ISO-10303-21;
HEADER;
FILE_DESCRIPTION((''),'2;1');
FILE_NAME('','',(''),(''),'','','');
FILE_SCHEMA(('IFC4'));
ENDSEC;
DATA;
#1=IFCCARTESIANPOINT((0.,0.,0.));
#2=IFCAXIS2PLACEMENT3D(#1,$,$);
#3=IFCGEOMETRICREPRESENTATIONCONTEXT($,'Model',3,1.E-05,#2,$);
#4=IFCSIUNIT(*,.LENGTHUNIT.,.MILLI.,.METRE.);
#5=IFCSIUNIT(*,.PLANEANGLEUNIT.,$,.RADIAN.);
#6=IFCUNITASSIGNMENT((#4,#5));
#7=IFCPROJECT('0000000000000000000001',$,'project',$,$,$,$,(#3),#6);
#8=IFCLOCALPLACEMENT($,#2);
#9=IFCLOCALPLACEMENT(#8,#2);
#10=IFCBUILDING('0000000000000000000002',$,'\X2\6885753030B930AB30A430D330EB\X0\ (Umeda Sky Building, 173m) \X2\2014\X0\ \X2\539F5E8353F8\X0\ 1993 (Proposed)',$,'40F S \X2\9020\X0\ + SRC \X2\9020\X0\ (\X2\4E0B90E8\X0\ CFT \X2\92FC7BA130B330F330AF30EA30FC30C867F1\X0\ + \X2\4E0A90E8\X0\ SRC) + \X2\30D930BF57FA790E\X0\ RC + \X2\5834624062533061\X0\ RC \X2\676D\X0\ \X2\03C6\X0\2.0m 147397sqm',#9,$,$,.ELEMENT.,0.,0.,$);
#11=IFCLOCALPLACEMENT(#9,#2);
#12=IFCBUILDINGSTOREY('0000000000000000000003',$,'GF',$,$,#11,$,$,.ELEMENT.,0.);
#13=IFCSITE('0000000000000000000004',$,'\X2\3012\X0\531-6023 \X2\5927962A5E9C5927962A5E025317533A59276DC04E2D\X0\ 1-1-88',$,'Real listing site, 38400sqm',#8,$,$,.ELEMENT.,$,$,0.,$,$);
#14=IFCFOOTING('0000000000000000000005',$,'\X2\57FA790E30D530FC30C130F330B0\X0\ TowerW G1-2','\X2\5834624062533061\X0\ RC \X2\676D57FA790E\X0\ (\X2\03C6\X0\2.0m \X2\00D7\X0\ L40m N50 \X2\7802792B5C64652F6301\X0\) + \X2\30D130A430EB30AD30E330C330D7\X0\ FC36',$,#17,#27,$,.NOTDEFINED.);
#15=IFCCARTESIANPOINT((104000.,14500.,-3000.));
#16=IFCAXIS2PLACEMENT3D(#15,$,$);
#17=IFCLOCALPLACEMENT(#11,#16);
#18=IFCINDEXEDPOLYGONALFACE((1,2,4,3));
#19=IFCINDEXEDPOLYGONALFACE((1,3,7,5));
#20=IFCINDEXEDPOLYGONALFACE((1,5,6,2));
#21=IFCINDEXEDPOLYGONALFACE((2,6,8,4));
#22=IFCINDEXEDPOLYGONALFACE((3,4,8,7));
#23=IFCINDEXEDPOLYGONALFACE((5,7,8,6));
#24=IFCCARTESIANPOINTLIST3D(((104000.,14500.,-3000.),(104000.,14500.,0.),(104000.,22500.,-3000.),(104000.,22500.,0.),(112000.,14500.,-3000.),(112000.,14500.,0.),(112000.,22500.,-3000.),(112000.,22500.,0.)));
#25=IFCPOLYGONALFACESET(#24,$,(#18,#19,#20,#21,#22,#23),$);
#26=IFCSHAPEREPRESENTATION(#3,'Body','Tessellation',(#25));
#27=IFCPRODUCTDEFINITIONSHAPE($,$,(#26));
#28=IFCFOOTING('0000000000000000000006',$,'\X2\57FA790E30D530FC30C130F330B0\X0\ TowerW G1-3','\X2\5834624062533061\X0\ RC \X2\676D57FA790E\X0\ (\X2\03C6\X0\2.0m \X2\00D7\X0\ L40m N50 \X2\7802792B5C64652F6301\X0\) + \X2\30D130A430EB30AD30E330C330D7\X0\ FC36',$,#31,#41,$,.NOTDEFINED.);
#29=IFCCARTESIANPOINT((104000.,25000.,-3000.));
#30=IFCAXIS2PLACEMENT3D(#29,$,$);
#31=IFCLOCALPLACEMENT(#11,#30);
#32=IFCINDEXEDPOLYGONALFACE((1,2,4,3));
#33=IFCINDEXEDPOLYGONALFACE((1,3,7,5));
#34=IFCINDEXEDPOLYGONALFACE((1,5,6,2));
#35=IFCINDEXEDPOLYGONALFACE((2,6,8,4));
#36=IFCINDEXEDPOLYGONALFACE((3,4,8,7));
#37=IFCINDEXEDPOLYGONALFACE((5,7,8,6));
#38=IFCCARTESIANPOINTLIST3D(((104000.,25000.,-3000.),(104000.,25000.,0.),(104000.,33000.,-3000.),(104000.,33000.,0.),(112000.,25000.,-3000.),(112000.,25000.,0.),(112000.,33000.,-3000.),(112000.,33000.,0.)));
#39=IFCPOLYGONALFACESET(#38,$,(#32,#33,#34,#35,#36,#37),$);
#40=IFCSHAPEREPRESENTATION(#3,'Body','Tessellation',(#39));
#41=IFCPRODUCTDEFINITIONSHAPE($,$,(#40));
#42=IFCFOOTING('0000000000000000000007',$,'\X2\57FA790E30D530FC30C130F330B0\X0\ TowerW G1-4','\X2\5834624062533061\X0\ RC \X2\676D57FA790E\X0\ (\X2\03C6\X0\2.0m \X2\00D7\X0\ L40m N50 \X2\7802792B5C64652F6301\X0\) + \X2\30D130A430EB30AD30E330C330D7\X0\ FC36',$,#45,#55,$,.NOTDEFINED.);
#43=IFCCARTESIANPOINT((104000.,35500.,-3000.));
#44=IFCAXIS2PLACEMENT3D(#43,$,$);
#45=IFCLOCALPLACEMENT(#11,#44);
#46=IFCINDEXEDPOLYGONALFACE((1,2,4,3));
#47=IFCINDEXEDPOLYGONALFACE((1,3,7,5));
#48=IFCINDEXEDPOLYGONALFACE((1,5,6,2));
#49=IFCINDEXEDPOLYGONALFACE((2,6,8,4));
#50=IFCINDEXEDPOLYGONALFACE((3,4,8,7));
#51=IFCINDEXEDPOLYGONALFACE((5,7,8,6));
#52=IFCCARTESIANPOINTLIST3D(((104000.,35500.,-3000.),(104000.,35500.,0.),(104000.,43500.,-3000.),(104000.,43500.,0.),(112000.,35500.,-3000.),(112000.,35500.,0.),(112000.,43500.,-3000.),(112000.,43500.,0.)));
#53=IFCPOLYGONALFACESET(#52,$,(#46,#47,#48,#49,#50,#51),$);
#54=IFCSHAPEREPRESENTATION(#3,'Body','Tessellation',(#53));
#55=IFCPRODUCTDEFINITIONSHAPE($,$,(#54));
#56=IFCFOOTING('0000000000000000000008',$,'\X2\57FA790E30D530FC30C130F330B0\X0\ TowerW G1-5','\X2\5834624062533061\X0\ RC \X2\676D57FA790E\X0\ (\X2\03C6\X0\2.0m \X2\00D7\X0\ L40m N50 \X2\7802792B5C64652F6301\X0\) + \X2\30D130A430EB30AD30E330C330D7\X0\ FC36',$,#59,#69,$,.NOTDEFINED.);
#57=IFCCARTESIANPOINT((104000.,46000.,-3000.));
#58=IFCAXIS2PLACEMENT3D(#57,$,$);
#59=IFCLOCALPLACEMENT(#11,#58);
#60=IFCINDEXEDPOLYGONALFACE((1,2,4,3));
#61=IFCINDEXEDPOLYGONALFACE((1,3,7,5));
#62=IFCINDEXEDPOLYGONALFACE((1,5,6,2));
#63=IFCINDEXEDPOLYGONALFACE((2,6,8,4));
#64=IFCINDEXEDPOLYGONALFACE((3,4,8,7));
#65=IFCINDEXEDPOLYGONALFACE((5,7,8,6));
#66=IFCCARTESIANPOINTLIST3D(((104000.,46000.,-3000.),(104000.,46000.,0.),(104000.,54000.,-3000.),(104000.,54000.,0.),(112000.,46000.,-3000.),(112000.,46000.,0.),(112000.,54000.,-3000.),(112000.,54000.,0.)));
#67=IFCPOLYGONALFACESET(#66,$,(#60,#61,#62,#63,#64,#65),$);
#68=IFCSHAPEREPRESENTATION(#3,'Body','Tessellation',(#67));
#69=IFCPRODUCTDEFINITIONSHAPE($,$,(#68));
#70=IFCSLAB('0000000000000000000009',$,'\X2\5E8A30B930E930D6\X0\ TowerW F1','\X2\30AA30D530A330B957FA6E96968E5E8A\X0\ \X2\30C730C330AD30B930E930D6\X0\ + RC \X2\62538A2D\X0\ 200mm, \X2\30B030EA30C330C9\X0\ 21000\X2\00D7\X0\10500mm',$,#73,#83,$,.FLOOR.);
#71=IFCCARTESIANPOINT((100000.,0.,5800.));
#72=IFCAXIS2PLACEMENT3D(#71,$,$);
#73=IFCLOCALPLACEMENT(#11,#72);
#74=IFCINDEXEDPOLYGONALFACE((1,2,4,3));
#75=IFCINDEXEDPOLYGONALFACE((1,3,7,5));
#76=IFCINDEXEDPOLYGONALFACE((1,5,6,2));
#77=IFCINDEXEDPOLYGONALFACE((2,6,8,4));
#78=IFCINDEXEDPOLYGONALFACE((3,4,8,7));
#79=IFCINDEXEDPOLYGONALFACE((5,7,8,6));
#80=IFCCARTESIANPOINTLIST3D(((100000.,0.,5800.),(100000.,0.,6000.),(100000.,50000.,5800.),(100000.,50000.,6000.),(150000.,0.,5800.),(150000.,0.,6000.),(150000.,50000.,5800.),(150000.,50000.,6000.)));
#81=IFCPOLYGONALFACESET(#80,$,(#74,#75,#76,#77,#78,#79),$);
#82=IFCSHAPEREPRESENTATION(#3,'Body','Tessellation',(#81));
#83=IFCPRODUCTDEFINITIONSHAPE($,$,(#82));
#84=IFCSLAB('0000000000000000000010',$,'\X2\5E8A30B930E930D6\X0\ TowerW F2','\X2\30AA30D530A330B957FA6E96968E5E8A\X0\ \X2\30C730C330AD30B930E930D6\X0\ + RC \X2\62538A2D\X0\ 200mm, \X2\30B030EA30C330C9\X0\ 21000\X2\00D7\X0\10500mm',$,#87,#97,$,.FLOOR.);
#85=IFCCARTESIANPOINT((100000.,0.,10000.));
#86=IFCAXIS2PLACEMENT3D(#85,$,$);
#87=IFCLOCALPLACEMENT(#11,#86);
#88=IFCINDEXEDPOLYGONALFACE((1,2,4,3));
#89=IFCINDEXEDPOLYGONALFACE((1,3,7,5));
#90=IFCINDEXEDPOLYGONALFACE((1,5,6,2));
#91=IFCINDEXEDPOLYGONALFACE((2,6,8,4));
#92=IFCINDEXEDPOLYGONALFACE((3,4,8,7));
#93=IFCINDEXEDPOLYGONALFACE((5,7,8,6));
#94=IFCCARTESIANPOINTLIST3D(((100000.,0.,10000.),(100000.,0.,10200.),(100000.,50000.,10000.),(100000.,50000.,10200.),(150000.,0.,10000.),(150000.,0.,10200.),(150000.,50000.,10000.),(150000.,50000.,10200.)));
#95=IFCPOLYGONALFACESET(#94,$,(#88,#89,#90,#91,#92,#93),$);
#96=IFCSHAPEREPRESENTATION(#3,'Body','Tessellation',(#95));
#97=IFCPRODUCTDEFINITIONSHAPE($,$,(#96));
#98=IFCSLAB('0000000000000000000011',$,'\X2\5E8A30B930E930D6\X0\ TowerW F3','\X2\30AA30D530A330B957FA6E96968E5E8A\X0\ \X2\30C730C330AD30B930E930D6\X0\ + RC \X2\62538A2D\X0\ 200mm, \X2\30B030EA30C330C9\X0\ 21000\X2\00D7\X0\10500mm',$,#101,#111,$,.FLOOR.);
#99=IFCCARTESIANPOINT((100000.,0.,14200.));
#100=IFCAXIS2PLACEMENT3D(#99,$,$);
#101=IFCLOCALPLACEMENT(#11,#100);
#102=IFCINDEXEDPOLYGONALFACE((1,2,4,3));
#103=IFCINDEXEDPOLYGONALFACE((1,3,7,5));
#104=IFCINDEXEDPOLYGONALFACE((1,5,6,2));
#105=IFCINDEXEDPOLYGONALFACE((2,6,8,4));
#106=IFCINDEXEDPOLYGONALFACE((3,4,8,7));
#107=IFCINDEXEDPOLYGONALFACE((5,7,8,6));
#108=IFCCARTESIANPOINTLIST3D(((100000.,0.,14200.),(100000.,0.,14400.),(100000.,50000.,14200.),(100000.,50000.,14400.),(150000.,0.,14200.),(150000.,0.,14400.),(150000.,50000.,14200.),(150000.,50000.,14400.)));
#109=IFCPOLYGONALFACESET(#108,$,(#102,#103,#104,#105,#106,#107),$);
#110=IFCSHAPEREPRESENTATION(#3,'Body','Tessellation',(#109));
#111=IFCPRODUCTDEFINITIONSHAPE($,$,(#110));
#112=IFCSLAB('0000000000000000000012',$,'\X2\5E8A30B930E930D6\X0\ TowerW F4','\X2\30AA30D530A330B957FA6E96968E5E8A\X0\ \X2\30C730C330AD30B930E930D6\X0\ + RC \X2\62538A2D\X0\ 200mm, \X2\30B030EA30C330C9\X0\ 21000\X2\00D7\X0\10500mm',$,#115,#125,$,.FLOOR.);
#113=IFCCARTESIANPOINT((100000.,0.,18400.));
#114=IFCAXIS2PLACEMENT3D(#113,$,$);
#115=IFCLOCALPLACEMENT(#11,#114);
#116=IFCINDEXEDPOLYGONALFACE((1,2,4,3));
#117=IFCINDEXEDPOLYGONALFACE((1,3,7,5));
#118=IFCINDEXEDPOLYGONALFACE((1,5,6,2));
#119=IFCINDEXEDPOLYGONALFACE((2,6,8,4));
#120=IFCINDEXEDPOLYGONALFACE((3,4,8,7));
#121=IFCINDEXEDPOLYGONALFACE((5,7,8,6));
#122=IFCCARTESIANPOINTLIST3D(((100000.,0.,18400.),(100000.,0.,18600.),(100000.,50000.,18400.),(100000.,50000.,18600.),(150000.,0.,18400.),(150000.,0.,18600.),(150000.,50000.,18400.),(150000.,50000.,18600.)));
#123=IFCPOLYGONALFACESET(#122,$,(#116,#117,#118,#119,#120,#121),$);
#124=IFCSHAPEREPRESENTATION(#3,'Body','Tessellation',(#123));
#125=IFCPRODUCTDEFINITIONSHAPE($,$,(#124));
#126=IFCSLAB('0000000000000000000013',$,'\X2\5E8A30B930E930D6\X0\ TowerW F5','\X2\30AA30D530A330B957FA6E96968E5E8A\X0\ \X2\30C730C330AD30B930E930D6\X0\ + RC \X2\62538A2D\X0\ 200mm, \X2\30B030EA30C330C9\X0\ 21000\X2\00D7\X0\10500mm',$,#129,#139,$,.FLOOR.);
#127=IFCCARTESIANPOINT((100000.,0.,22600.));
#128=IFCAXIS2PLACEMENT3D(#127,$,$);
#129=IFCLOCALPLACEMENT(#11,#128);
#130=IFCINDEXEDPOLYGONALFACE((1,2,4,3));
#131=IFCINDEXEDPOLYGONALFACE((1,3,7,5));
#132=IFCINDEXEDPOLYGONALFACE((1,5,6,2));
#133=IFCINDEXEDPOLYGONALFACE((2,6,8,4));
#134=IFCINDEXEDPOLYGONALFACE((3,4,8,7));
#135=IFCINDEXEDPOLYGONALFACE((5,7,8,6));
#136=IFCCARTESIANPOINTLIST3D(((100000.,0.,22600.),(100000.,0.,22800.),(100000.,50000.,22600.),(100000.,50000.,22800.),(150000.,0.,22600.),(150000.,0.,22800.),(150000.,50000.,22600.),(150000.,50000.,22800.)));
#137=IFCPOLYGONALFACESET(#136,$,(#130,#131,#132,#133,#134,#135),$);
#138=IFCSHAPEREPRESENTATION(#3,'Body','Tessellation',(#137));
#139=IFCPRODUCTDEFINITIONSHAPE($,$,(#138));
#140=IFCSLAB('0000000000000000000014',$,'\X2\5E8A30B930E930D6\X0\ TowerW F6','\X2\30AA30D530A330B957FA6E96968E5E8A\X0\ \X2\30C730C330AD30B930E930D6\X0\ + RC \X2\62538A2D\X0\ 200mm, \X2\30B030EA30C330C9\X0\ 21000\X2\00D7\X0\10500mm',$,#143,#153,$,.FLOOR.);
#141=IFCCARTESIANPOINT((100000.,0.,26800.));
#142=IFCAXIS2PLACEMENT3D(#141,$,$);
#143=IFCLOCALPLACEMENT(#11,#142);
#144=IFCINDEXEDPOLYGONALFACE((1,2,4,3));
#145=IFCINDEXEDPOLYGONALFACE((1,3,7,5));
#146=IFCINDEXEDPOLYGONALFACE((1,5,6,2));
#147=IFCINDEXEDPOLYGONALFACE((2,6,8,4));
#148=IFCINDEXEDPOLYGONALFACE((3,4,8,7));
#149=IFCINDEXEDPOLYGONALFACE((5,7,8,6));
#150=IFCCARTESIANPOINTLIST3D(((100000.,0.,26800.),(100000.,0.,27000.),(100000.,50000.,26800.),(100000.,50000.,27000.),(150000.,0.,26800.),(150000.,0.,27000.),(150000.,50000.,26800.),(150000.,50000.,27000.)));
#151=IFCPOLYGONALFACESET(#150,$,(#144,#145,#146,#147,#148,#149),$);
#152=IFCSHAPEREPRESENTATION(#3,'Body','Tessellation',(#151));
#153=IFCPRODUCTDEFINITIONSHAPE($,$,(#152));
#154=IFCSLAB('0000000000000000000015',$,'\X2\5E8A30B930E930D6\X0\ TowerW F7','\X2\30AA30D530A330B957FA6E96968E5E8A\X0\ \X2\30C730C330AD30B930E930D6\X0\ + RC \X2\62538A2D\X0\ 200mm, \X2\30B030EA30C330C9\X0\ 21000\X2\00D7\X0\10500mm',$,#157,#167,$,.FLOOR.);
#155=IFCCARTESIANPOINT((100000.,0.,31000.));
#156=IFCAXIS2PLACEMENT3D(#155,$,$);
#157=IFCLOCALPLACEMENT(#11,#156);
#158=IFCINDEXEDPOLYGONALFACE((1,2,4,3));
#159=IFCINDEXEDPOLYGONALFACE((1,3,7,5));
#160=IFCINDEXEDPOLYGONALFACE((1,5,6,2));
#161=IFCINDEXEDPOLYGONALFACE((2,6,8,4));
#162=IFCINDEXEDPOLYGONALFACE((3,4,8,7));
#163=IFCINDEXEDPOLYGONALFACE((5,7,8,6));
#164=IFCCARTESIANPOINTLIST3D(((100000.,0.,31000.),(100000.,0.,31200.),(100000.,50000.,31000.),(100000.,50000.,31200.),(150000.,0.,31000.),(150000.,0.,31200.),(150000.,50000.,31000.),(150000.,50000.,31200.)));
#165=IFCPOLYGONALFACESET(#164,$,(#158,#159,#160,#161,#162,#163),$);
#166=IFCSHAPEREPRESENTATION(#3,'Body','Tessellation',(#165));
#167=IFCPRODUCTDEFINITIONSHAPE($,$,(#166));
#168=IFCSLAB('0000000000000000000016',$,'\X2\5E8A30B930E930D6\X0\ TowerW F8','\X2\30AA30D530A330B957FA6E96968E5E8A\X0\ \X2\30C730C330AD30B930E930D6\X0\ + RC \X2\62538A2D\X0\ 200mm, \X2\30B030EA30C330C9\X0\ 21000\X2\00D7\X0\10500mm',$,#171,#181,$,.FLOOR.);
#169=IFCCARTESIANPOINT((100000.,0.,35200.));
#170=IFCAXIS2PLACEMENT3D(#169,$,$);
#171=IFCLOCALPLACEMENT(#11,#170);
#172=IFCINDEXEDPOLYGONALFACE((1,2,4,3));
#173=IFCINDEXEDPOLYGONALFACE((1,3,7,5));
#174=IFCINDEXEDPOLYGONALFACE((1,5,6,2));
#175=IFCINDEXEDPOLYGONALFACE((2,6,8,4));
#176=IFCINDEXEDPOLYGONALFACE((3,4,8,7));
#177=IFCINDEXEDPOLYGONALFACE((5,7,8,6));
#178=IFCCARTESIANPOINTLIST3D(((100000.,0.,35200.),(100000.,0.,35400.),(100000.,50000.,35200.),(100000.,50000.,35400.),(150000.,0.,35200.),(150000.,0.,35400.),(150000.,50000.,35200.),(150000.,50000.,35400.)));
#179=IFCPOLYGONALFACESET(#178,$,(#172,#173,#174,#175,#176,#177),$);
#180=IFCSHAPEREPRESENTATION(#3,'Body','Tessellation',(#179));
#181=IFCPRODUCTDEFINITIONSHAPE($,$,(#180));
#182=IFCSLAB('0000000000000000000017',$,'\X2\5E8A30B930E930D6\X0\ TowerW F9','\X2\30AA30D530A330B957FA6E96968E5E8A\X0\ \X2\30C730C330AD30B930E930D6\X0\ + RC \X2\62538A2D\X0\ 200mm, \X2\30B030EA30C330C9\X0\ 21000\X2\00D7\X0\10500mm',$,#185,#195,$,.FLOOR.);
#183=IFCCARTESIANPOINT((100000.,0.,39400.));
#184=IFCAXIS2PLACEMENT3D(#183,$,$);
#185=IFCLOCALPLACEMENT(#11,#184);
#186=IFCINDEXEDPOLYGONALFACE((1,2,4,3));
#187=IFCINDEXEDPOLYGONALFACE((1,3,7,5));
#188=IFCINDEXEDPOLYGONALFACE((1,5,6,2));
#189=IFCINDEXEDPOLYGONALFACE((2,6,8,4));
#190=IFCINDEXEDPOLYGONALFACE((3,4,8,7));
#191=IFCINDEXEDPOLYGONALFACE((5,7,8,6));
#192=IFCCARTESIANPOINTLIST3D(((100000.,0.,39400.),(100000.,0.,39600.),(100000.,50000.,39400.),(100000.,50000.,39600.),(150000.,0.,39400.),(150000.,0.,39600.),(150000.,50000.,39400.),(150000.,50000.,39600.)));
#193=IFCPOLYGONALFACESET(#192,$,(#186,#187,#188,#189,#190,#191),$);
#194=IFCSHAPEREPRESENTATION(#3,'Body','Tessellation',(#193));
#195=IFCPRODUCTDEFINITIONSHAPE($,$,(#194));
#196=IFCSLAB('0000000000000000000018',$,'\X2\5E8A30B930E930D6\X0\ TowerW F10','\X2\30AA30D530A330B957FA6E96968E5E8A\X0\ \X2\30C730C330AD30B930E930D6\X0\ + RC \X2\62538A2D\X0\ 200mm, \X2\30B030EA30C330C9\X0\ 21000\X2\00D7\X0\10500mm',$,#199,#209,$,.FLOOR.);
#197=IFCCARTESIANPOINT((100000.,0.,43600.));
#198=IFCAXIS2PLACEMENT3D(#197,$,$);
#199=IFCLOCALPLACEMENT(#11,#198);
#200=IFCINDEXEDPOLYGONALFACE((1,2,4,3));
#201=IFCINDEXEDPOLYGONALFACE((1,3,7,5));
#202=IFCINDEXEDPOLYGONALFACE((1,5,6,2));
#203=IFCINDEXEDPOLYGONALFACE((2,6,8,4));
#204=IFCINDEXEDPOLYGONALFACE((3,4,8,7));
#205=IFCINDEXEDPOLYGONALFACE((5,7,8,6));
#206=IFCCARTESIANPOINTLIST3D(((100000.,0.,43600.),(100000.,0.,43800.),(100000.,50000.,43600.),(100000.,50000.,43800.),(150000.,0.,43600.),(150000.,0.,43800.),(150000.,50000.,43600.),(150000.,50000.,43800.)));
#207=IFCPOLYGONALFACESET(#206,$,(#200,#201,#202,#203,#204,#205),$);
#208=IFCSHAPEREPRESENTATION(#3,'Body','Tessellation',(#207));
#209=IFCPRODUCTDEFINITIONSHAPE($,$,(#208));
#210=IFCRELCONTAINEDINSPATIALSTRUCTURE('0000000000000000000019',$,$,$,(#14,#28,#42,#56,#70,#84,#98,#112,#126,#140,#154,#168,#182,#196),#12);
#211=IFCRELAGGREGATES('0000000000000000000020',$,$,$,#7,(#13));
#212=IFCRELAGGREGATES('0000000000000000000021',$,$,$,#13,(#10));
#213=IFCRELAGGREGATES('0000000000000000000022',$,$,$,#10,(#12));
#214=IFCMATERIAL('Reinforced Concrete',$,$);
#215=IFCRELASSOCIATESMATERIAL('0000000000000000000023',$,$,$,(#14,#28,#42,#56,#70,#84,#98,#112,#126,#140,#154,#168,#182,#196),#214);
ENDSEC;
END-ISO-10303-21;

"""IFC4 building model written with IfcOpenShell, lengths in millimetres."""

from ifc_helpers import new_model, si_unit, frame, frame_2d, origin, place, context, project, spatial, rectangle, extrude, material, element, save


model = new_model("IFC4")

# Units and contexts
model_context = context("Model", 3, precision=1e-05, world=origin())
ifc_project = project(units=[si_unit("LENGTHUNIT", "METRE", prefix="MILLI"), si_unit("PLANEANGLEUNIT", "RADIAN")], contexts=[model_context])

# Site, building, storey
site_placement = place(None, origin())
site = spatial("IfcSite", under=ifc_project, at=site_placement, Name="〒531-6023 大阪府大阪市北区大淀中 1-1-88", ObjectType="Real listing site, 38400sqm", CompositionType="ELEMENT", RefElevation=0.0)
building_placement = place(site_placement, origin())
building = spatial("IfcBuilding", under=site, at=building_placement, Name="梅田スカイビル (Umeda Sky Building, 173m) — 原広司 1993 (Proposed)", ObjectType="40F S 造 + SRC 造 (下部 CFT 鋼管コンクリート柱 + 上部 SRC) + ベタ基礎 RC + 場所打ち RC 杭 φ2.0m 147397sqm", CompositionType="ELEMENT", ElevationOfRefHeight=0.0, ElevationOfTerrain=0.0)
storey_placement = place(building_placement, origin())
storey = spatial("IfcBuildingStorey", under=building, at=storey_placement, Name="GF", CompositionType="ELEMENT", Elevation=0.0)

# Footings
ifc_material_1 = material(Name="Reinforced Concrete")
footing_1_placement = place(storey_placement, frame((104000.0, 14500.0, -3000.0)))
element("IfcFooting", 1, at=footing_1_placement, inside=storey, material=ifc_material_1, Name="基礎フーチング TowerW G1-2", Description="場所打ち RC 杭基礎 (φ2.0m × L40m N50 砂礫層支持) + パイルキャップ FC36", PredefinedType="NOTDEFINED", context=model_context, shape_type="SweptSolid", body=[
    extrude(rectangle(XDim=8000.0, YDim=8000.0, at=frame_2d((4000.0, 4000.0))), frame((104000.0, 14500.0, -3000.0)), (0.0, 0.0, 1.0), 3000.0),
])
footing_2_placement = place(storey_placement, frame((104000.0, 25000.0, -3000.0)))
element("IfcFooting", 2, at=footing_2_placement, inside=storey, material=ifc_material_1, Name="基礎フーチング TowerW G1-3", Description="場所打ち RC 杭基礎 (φ2.0m × L40m N50 砂礫層支持) + パイルキャップ FC36", PredefinedType="NOTDEFINED", context=model_context, shape_type="SweptSolid", body=[
    extrude(rectangle(XDim=8000.0, YDim=8000.0, at=frame_2d((4000.0, 4000.0))), frame((104000.0, 25000.0, -3000.0)), (0.0, 0.0, 1.0), 3000.0),
])
footing_3_placement = place(storey_placement, frame((104000.0, 35500.0, -3000.0)))
element("IfcFooting", 3, at=footing_3_placement, inside=storey, material=ifc_material_1, Name="基礎フーチング TowerW G1-4", Description="場所打ち RC 杭基礎 (φ2.0m × L40m N50 砂礫層支持) + パイルキャップ FC36", PredefinedType="NOTDEFINED", context=model_context, shape_type="SweptSolid", body=[
    extrude(rectangle(XDim=8000.0, YDim=8000.0, at=frame_2d((4000.0, 4000.0))), frame((104000.0, 35500.0, -3000.0)), (0.0, 0.0, 1.0), 3000.0),
])
footing_4_placement = place(storey_placement, frame((104000.0, 46000.0, -3000.0)))
element("IfcFooting", 4, at=footing_4_placement, inside=storey, material=ifc_material_1, Name="基礎フーチング TowerW G1-5", Description="場所打ち RC 杭基礎 (φ2.0m × L40m N50 砂礫層支持) + パイルキャップ FC36", PredefinedType="NOTDEFINED", context=model_context, shape_type="SweptSolid", body=[
    extrude(rectangle(XDim=8000.0, YDim=8000.0, at=frame_2d((4000.0, 4000.0))), frame((104000.0, 46000.0, -3000.0)), (0.0, 0.0, 1.0), 3000.0),
])

# Slabs
slab_1_placement = place(storey_placement, frame((100000.0, 0.0, 5800.0)))
element("IfcSlab", 5, at=slab_1_placement, inside=storey, material=ifc_material_1, Name="床スラブ TowerW F1", Description="オフィス基準階床 デッキスラブ + RC 打設 200mm, グリッド 21000×10500mm", PredefinedType="FLOOR", context=model_context, shape_type="SweptSolid", body=[
    extrude(rectangle(XDim=50000.0, YDim=50000.0, at=frame_2d((25000.0, 25000.0))), frame((100000.0, 0.0, 5800.0)), (0.0, 0.0, 1.0), 200.0),
])
slab_2_placement = place(storey_placement, frame((100000.0, 0.0, 10000.0)))
element("IfcSlab", 6, at=slab_2_placement, inside=storey, material=ifc_material_1, Name="床スラブ TowerW F2", Description="オフィス基準階床 デッキスラブ + RC 打設 200mm, グリッド 21000×10500mm", PredefinedType="FLOOR", context=model_context, shape_type="SweptSolid", body=[
    extrude(rectangle(XDim=50000.0, YDim=50000.0, at=frame_2d((25000.0, 25000.0))), frame((100000.0, 0.0, 10000.0)), (0.0, 0.0, 1.0), 200.0),
])
slab_3_placement = place(storey_placement, frame((100000.0, 0.0, 14200.0)))
element("IfcSlab", 7, at=slab_3_placement, inside=storey, material=ifc_material_1, Name="床スラブ TowerW F3", Description="オフィス基準階床 デッキスラブ + RC 打設 200mm, グリッド 21000×10500mm", PredefinedType="FLOOR", context=model_context, shape_type="SweptSolid", body=[
    extrude(rectangle(XDim=50000.0, YDim=50000.0, at=frame_2d((25000.0, 25000.0))), frame((100000.0, 0.0, 14200.0)), (0.0, 0.0, 1.0), 200.0),
])
slab_4_placement = place(storey_placement, frame((100000.0, 0.0, 18400.0)))
element("IfcSlab", 8, at=slab_4_placement, inside=storey, material=ifc_material_1, Name="床スラブ TowerW F4", Description="オフィス基準階床 デッキスラブ + RC 打設 200mm, グリッド 21000×10500mm", PredefinedType="FLOOR", context=model_context, shape_type="SweptSolid", body=[
    extrude(rectangle(XDim=50000.0, YDim=50000.0, at=frame_2d((25000.0, 25000.0))), frame((100000.0, 0.0, 18400.0)), (0.0, 0.0, 1.0), 200.0),
])
slab_5_placement = place(storey_placement, frame((100000.0, 0.0, 22600.0)))
element("IfcSlab", 9, at=slab_5_placement, inside=storey, material=ifc_material_1, Name="床スラブ TowerW F5", Description="オフィス基準階床 デッキスラブ + RC 打設 200mm, グリッド 21000×10500mm", PredefinedType="FLOOR", context=model_context, shape_type="SweptSolid", body=[
    extrude(rectangle(XDim=50000.0, YDim=50000.0, at=frame_2d((25000.0, 25000.0))), frame((100000.0, 0.0, 22600.0)), (0.0, 0.0, 1.0), 200.0),
])
slab_6_placement = place(storey_placement, frame((100000.0, 0.0, 26800.0)))
element("IfcSlab", 10, at=slab_6_placement, inside=storey, material=ifc_material_1, Name="床スラブ TowerW F6", Description="オフィス基準階床 デッキスラブ + RC 打設 200mm, グリッド 21000×10500mm", PredefinedType="FLOOR", context=model_context, shape_type="SweptSolid", body=[
    extrude(rectangle(XDim=50000.0, YDim=50000.0, at=frame_2d((25000.0, 25000.0))), frame((100000.0, 0.0, 26800.0)), (0.0, 0.0, 1.0), 200.0),
])
slab_7_placement = place(storey_placement, frame((100000.0, 0.0, 31000.0)))
element("IfcSlab", 11, at=slab_7_placement, inside=storey, material=ifc_material_1, Name="床スラブ TowerW F7", Description="オフィス基準階床 デッキスラブ + RC 打設 200mm, グリッド 21000×10500mm", PredefinedType="FLOOR", context=model_context, shape_type="SweptSolid", body=[
    extrude(rectangle(XDim=50000.0, YDim=50000.0, at=frame_2d((25000.0, 25000.0))), frame((100000.0, 0.0, 31000.0)), (0.0, 0.0, 1.0), 200.0),
])
slab_8_placement = place(storey_placement, frame((100000.0, 0.0, 35200.0)))
element("IfcSlab", 12, at=slab_8_placement, inside=storey, material=ifc_material_1, Name="床スラブ TowerW F8", Description="オフィス基準階床 デッキスラブ + RC 打設 200mm, グリッド 21000×10500mm", PredefinedType="FLOOR", context=model_context, shape_type="SweptSolid", body=[
    extrude(rectangle(XDim=50000.0, YDim=50000.0, at=frame_2d((25000.0, 25000.0))), frame((100000.0, 0.0, 35200.0)), (0.0, 0.0, 1.0), 200.0),
])
slab_9_placement = place(storey_placement, frame((100000.0, 0.0, 39400.0)))
element("IfcSlab", 13, at=slab_9_placement, inside=storey, material=ifc_material_1, Name="床スラブ TowerW F9", Description="オフィス基準階床 デッキスラブ + RC 打設 200mm, グリッド 21000×10500mm", PredefinedType="FLOOR", context=model_context, shape_type="SweptSolid", body=[
    extrude(rectangle(XDim=50000.0, YDim=50000.0, at=frame_2d((25000.0, 25000.0))), frame((100000.0, 0.0, 39400.0)), (0.0, 0.0, 1.0), 200.0),
])
slab_10_placement = place(storey_placement, frame((100000.0, 0.0, 43600.0)))
element("IfcSlab", 14, at=slab_10_placement, inside=storey, material=ifc_material_1, Name="床スラブ TowerW F10", Description="オフィス基準階床 デッキスラブ + RC 打設 200mm, グリッド 21000×10500mm", PredefinedType="FLOOR", context=model_context, shape_type="SweptSolid", body=[
    extrude(rectangle(XDim=50000.0, YDim=50000.0, at=frame_2d((25000.0, 25000.0))), frame((100000.0, 0.0, 43600.0)), (0.0, 0.0, 1.0), 200.0),
])

save(model, "model.ifc")
